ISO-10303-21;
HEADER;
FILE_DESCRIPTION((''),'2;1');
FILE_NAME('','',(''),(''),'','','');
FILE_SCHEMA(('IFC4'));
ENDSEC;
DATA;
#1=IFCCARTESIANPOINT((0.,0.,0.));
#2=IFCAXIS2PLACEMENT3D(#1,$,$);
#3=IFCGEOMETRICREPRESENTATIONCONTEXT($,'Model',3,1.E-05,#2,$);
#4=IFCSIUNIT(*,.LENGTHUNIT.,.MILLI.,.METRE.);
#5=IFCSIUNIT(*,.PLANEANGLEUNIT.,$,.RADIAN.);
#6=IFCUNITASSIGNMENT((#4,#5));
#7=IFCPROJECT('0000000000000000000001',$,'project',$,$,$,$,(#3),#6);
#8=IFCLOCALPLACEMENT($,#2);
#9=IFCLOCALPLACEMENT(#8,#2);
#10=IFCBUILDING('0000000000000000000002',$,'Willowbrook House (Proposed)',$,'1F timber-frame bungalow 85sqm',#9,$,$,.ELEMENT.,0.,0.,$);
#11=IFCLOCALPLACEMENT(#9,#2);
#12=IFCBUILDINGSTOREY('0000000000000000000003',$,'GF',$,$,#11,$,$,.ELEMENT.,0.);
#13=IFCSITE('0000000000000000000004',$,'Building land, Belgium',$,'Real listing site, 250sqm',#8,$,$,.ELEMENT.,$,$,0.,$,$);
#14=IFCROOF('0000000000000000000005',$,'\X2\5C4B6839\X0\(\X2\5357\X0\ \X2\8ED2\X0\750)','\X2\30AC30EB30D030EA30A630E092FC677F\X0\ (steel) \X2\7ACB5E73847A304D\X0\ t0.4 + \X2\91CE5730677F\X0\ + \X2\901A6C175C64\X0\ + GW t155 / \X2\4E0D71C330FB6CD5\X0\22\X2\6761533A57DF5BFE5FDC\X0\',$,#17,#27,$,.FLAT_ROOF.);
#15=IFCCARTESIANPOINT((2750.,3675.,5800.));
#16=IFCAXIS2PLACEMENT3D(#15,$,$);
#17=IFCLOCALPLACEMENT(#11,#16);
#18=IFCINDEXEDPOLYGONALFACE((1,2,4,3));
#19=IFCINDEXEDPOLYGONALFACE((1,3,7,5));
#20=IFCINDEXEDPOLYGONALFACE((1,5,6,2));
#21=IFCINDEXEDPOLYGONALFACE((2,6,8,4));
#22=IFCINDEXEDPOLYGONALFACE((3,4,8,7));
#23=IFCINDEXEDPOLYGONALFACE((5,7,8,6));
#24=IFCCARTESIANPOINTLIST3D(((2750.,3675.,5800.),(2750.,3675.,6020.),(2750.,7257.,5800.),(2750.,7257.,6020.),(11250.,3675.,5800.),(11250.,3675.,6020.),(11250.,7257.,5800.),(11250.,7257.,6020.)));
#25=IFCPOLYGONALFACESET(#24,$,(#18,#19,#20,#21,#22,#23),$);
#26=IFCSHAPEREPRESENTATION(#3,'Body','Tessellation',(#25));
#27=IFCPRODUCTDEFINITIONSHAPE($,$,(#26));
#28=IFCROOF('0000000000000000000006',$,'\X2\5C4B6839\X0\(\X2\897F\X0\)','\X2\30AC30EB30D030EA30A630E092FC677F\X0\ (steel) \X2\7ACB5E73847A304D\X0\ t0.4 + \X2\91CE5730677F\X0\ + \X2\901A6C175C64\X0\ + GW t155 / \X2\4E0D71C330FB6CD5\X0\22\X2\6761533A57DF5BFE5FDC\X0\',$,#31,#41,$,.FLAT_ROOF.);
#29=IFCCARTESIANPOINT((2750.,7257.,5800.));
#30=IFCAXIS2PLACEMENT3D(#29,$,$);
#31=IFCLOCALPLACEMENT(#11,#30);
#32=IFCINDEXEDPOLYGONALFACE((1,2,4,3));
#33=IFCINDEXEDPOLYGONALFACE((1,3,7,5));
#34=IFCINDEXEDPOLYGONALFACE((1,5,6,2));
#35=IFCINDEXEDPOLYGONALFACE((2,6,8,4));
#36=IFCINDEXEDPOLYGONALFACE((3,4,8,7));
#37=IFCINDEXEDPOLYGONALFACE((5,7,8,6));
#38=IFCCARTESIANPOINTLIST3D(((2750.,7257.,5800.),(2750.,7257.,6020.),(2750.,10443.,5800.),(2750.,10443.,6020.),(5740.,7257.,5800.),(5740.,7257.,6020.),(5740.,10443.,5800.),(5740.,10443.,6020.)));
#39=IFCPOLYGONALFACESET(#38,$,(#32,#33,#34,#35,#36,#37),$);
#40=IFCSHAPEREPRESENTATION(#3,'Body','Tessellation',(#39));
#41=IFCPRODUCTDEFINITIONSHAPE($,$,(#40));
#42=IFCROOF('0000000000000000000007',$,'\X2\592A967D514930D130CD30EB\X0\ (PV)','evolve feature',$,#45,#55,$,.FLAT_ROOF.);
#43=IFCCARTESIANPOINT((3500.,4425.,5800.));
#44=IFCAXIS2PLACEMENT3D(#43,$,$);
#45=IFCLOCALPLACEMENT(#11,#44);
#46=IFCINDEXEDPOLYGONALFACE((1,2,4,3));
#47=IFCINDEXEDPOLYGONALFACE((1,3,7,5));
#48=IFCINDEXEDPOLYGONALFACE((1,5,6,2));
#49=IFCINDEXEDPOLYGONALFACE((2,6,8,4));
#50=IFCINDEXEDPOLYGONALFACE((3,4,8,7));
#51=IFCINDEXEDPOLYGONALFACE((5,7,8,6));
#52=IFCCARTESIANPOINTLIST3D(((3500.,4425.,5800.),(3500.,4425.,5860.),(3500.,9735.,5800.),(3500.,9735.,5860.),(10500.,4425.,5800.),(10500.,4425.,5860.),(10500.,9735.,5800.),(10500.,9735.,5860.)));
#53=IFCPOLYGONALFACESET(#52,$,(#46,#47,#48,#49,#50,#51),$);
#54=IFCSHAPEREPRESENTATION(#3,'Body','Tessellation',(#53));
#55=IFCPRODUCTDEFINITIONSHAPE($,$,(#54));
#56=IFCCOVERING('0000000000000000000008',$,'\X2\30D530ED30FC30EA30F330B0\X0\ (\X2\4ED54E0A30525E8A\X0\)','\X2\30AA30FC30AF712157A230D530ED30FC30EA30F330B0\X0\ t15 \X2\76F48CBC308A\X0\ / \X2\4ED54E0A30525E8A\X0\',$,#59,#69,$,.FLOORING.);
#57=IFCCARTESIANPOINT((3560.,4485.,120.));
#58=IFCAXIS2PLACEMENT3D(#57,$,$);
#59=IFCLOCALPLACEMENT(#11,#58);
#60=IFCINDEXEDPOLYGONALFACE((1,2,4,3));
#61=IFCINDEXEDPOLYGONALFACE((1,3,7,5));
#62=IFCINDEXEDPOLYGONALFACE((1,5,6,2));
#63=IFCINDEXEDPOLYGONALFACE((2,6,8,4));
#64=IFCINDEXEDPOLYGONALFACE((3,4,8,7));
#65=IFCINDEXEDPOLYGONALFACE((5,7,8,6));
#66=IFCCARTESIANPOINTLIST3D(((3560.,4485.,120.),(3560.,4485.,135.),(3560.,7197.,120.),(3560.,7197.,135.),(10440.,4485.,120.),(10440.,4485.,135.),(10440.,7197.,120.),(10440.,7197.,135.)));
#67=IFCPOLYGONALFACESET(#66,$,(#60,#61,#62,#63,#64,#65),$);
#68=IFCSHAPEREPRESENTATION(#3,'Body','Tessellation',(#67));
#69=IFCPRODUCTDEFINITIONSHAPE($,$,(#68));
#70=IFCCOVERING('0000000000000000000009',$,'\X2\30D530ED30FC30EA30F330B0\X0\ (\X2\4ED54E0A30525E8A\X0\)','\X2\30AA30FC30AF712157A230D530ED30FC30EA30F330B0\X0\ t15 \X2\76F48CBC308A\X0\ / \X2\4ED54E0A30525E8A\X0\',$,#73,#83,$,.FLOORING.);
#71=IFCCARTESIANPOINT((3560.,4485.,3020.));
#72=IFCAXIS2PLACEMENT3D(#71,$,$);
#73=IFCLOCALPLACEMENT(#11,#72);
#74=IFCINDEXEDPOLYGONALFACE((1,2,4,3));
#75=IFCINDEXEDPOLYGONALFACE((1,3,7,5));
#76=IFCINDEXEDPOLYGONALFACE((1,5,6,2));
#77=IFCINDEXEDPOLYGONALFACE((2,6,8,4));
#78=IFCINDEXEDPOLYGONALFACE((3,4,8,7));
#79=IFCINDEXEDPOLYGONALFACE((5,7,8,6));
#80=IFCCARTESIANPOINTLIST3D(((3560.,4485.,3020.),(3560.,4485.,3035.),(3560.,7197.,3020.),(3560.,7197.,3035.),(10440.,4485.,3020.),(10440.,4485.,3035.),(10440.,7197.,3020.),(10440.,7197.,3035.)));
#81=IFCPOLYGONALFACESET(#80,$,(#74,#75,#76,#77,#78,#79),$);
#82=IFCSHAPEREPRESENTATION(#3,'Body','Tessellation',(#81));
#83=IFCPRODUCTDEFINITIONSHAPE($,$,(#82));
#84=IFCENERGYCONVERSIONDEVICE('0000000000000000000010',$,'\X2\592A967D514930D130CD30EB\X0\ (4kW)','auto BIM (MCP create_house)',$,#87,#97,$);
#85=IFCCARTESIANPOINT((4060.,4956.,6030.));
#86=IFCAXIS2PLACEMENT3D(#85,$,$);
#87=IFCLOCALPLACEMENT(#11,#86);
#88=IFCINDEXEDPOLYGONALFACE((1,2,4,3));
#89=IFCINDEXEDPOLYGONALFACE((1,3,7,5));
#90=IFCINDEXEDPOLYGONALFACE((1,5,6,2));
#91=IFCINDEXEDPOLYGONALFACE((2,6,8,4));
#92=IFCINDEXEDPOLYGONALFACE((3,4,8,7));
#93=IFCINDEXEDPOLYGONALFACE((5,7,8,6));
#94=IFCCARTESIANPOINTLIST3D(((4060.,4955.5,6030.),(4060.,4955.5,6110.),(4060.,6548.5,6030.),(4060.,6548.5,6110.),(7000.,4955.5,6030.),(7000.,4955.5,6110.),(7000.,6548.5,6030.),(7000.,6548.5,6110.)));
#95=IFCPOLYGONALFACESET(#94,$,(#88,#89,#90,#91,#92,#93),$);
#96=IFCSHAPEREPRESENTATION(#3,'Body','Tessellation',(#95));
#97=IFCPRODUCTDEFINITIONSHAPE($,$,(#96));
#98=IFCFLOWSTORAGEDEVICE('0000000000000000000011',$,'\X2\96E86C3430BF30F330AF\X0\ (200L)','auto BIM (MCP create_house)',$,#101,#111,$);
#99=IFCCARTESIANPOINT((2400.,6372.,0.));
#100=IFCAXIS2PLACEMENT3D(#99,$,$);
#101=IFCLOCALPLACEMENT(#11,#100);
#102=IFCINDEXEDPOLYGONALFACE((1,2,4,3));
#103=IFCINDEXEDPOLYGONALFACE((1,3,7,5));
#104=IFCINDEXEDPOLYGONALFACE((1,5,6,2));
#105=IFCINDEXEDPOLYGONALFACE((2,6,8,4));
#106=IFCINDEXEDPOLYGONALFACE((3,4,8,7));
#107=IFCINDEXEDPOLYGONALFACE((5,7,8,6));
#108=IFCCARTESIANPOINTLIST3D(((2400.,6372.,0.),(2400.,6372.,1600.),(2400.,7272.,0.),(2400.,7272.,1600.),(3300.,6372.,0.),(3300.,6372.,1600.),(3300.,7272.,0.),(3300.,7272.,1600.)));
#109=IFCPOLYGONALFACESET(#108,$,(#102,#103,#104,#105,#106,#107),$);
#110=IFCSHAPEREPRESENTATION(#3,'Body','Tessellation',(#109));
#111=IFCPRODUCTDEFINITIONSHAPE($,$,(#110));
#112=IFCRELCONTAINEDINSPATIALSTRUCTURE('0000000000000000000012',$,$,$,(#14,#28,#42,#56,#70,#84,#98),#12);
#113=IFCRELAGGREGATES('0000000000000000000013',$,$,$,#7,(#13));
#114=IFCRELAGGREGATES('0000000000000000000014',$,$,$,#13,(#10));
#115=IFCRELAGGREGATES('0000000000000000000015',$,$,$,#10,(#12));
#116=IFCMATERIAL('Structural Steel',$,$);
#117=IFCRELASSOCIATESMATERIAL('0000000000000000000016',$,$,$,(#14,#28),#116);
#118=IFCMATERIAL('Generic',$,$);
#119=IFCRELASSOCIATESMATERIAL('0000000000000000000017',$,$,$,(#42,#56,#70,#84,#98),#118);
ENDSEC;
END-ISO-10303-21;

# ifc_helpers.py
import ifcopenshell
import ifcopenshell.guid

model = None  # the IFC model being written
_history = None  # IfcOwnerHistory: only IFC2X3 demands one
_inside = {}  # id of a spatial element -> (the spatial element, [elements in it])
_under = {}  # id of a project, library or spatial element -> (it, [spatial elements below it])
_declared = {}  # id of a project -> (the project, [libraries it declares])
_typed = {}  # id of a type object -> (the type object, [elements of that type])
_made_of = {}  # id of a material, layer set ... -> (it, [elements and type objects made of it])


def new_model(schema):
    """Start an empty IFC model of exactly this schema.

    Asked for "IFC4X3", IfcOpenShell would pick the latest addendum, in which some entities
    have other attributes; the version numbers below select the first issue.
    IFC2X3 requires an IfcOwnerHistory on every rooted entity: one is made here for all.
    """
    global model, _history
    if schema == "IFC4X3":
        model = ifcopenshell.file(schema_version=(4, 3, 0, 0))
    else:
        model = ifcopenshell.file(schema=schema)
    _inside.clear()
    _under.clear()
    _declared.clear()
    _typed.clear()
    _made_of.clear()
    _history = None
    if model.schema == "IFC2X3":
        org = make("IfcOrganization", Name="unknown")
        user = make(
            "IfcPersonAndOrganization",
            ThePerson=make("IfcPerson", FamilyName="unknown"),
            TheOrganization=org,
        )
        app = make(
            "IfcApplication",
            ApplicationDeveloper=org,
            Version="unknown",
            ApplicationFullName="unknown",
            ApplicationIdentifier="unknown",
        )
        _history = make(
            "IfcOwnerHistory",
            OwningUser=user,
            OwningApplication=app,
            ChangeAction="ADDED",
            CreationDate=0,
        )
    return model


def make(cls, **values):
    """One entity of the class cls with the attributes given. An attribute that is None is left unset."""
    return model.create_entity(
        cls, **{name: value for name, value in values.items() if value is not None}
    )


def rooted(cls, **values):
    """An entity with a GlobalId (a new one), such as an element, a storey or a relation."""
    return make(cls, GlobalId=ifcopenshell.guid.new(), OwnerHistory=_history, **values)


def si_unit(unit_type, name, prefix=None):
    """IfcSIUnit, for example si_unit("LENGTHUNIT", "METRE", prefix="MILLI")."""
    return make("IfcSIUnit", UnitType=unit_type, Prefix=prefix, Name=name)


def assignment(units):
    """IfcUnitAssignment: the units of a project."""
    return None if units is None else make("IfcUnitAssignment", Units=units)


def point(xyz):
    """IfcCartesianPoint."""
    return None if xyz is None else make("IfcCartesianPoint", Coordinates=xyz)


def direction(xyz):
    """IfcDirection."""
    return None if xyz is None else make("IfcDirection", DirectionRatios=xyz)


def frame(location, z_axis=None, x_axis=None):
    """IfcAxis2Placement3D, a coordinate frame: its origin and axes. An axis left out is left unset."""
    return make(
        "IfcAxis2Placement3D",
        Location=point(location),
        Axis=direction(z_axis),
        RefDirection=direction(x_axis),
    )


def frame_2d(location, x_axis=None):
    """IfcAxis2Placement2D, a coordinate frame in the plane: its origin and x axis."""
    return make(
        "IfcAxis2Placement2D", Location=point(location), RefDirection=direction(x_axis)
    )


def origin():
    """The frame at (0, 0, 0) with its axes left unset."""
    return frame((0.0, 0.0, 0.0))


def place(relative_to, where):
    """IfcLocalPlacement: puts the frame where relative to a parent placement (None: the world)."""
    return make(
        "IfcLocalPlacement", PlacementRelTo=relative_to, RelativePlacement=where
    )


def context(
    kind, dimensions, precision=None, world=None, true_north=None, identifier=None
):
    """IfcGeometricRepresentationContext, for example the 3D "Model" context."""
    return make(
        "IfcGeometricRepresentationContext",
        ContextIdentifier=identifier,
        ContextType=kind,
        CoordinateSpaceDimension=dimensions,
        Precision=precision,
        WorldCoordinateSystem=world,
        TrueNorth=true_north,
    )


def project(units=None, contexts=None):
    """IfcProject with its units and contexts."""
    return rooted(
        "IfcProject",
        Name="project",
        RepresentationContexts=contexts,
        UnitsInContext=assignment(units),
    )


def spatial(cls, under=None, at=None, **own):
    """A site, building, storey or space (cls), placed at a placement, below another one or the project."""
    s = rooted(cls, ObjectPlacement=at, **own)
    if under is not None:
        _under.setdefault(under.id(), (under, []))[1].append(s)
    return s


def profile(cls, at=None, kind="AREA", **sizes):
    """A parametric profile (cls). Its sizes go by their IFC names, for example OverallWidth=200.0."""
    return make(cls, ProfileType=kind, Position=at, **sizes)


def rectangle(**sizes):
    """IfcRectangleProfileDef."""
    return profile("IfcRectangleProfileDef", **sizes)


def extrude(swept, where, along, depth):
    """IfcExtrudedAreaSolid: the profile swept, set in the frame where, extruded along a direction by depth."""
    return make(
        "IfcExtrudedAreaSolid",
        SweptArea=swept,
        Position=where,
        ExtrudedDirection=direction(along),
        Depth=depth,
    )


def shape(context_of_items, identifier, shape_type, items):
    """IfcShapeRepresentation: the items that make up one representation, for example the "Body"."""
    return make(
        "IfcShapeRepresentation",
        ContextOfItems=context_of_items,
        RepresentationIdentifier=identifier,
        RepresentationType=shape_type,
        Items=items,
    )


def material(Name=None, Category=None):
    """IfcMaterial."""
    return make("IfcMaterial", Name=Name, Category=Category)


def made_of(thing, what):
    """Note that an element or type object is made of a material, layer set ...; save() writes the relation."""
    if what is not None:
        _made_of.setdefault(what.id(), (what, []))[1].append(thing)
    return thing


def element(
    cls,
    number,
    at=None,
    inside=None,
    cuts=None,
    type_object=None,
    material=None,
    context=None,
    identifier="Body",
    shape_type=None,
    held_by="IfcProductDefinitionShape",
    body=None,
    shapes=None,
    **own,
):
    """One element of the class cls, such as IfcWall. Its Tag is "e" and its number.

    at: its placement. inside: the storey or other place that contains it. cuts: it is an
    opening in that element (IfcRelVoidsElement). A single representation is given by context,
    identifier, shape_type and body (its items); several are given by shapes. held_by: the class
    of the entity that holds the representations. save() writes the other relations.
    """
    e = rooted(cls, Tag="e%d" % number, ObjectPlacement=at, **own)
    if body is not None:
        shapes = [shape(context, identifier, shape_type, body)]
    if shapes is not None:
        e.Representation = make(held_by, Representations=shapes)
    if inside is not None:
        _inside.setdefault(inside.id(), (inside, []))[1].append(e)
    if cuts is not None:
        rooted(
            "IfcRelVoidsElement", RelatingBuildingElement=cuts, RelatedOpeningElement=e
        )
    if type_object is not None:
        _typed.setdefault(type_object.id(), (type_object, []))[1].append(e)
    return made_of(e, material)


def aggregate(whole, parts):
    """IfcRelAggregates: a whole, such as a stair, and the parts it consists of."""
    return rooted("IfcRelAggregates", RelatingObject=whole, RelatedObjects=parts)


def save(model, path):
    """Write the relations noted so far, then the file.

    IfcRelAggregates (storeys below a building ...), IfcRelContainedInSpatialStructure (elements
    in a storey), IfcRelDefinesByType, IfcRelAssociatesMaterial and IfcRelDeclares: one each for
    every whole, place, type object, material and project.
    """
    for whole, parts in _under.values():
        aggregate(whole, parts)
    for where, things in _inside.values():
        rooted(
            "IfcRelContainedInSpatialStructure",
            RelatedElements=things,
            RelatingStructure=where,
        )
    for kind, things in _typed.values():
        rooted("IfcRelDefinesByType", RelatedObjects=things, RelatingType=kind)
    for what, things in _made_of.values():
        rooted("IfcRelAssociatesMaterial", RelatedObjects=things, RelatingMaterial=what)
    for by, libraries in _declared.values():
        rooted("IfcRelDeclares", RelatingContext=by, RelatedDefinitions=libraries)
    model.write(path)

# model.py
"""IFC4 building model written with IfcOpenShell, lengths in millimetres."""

from ifc_helpers import new_model, si_unit, frame, frame_2d, origin, place, context, project, spatial, rectangle, extrude, material, element, save


model = new_model("IFC4")

# Units and contexts
model_context = context("Model", 3, precision=1e-05, world=origin())
ifc_project = project(units=[si_unit("LENGTHUNIT", "METRE", prefix="MILLI"), si_unit("PLANEANGLEUNIT", "RADIAN")], contexts=[model_context])

# Site, building, storey
site_placement = place(None, origin())
site = spatial("IfcSite", under=ifc_project, at=site_placement, Name="Building land, Belgium", ObjectType="Real listing site, 250sqm", CompositionType="ELEMENT", RefElevation=0.0)
building_placement = place(site_placement, origin())
building = spatial("IfcBuilding", under=site, at=building_placement, Name="Willowbrook House (Proposed)", ObjectType="1F timber-frame bungalow 85sqm", CompositionType="ELEMENT", ElevationOfRefHeight=0.0, ElevationOfTerrain=0.0)
storey_placement = place(building_placement, origin())
storey = spatial("IfcBuildingStorey", under=building, at=storey_placement, Name="GF", CompositionType="ELEMENT", Elevation=0.0)

# Shared definitions
ifc_material_1 = material(Name="Generic")

# Roofs
ifc_material_2 = material(Name="Structural Steel")
roof_1_placement = place(storey_placement, frame((2750.0, 3675.0, 5800.0)))
element("IfcRoof", 1, at=roof_1_placement, inside=storey, material=ifc_material_2, Name="屋根(南 軒750)", Description="ガルバリウム鋼板 (steel) 立平葺き t0.4 + 野地板 + 通気層 + GW t155 / 不燃・法22条区域対応", PredefinedType="FLAT_ROOF", context=model_context, shape_type="SweptSolid", body=[
    extrude(rectangle(XDim=8500.0, YDim=3582.0, at=frame_2d((4250.0, 1791.0))), frame((2750.0, 3675.0, 5800.0)), (0.0, 0.0, 1.0), 220.0),
])
roof_2_placement = place(storey_placement, frame((2750.0, 7257.0, 5800.0)))
element("IfcRoof", 2, at=roof_2_placement, inside=storey, material=ifc_material_2, Name="屋根(西)", Description="ガルバリウム鋼板 (steel) 立平葺き t0.4 + 野地板 + 通気層 + GW t155 / 不燃・法22条区域対応", PredefinedType="FLAT_ROOF", context=model_context, shape_type="SweptSolid", body=[
    extrude(rectangle(XDim=2990.0, YDim=3186.0, at=frame_2d((1495.0, 1593.0))), frame((2750.0, 7257.0, 5800.0)), (0.0, 0.0, 1.0), 220.0),
])
roof_3_placement = place(storey_placement, frame((3500.0, 4425.0, 5800.0)))
element("IfcRoof", 3, at=roof_3_placement, inside=storey, material=ifc_material_1, Name="太陽光パネル (PV)", Description="evolve feature", PredefinedType="FLAT_ROOF", context=model_context, shape_type="SweptSolid", body=[
    extrude(rectangle(XDim=7000.0, YDim=5310.0, at=frame_2d((3500.0, 2655.0))), frame((3500.0, 4425.0, 5800.0)), (0.0, 0.0, 1.0), 60.0),
])

# Coverings
covering_1_placement = place(storey_placement, frame((3560.0, 4485.0, 120.0)))
element("IfcCovering", 4, at=covering_1_placement, inside=storey, material=ifc_material_1, Name="フローリング (仕上げ床)", Description="オーク無垢フローリング t15 直貼り / 仕上げ床", PredefinedType="FLOORING", context=model_context, shape_type="SweptSolid", body=[
    extrude(rectangle(XDim=6880.0, YDim=2712.0, at=frame_2d((3440.0, 1356.0))), frame((3560.0, 4485.0, 120.0)), (0.0, 0.0, 1.0), 15.0),
])
covering_2_placement = place(storey_placement, frame((3560.0, 4485.0, 3020.0)))
element("IfcCovering", 5, at=covering_2_placement, inside=storey, material=ifc_material_1, Name="フローリング (仕上げ床)", Description="オーク無垢フローリング t15 直貼り / 仕上げ床", PredefinedType="FLOORING", context=model_context, shape_type="SweptSolid", body=[
    extrude(rectangle(XDim=6880.0, YDim=2712.0, at=frame_2d((3440.0, 1356.0))), frame((3560.0, 4485.0, 3020.0)), (0.0, 0.0, 1.0), 15.0),
])

# Energy conversion device
energy_conversion_device_placement = place(storey_placement, frame((4060.0, 4956.0, 6030.0)))
element("IfcEnergyConversionDevice", 6, at=energy_conversion_device_placement, inside=storey, material=ifc_material_1, Name="太陽光パネル (4kW)", Description="auto BIM (MCP create_house)", context=model_context, shape_type="SweptSolid", body=[
    extrude(rectangle(XDim=2940.0, YDim=1593.0, at=frame_2d((1470.0, 796.0))), frame((4060.0, 4956.0, 6030.0)), (0.0, 0.0, 1.0), 80.0),
])

# Flow storage device
flow_storage_device_placement = place(storey_placement, frame((2400.0, 6372.0, 0.0)))
element("IfcFlowStorageDevice", 7, at=flow_storage_device_placement, inside=storey, material=ifc_material_1, Name="雨水タンク (200L)", Description="auto BIM (MCP create_house)", context=model_context, shape_type="SweptSolid", body=[
    extrude(rectangle(XDim=900.0, YDim=900.0, at=frame_2d((450.0, 450.0))), frame((2400.0, 6372.0, 0.0)), (0.0, 0.0, 1.0), 1600.0),
])

save(model, "model.ifc")
